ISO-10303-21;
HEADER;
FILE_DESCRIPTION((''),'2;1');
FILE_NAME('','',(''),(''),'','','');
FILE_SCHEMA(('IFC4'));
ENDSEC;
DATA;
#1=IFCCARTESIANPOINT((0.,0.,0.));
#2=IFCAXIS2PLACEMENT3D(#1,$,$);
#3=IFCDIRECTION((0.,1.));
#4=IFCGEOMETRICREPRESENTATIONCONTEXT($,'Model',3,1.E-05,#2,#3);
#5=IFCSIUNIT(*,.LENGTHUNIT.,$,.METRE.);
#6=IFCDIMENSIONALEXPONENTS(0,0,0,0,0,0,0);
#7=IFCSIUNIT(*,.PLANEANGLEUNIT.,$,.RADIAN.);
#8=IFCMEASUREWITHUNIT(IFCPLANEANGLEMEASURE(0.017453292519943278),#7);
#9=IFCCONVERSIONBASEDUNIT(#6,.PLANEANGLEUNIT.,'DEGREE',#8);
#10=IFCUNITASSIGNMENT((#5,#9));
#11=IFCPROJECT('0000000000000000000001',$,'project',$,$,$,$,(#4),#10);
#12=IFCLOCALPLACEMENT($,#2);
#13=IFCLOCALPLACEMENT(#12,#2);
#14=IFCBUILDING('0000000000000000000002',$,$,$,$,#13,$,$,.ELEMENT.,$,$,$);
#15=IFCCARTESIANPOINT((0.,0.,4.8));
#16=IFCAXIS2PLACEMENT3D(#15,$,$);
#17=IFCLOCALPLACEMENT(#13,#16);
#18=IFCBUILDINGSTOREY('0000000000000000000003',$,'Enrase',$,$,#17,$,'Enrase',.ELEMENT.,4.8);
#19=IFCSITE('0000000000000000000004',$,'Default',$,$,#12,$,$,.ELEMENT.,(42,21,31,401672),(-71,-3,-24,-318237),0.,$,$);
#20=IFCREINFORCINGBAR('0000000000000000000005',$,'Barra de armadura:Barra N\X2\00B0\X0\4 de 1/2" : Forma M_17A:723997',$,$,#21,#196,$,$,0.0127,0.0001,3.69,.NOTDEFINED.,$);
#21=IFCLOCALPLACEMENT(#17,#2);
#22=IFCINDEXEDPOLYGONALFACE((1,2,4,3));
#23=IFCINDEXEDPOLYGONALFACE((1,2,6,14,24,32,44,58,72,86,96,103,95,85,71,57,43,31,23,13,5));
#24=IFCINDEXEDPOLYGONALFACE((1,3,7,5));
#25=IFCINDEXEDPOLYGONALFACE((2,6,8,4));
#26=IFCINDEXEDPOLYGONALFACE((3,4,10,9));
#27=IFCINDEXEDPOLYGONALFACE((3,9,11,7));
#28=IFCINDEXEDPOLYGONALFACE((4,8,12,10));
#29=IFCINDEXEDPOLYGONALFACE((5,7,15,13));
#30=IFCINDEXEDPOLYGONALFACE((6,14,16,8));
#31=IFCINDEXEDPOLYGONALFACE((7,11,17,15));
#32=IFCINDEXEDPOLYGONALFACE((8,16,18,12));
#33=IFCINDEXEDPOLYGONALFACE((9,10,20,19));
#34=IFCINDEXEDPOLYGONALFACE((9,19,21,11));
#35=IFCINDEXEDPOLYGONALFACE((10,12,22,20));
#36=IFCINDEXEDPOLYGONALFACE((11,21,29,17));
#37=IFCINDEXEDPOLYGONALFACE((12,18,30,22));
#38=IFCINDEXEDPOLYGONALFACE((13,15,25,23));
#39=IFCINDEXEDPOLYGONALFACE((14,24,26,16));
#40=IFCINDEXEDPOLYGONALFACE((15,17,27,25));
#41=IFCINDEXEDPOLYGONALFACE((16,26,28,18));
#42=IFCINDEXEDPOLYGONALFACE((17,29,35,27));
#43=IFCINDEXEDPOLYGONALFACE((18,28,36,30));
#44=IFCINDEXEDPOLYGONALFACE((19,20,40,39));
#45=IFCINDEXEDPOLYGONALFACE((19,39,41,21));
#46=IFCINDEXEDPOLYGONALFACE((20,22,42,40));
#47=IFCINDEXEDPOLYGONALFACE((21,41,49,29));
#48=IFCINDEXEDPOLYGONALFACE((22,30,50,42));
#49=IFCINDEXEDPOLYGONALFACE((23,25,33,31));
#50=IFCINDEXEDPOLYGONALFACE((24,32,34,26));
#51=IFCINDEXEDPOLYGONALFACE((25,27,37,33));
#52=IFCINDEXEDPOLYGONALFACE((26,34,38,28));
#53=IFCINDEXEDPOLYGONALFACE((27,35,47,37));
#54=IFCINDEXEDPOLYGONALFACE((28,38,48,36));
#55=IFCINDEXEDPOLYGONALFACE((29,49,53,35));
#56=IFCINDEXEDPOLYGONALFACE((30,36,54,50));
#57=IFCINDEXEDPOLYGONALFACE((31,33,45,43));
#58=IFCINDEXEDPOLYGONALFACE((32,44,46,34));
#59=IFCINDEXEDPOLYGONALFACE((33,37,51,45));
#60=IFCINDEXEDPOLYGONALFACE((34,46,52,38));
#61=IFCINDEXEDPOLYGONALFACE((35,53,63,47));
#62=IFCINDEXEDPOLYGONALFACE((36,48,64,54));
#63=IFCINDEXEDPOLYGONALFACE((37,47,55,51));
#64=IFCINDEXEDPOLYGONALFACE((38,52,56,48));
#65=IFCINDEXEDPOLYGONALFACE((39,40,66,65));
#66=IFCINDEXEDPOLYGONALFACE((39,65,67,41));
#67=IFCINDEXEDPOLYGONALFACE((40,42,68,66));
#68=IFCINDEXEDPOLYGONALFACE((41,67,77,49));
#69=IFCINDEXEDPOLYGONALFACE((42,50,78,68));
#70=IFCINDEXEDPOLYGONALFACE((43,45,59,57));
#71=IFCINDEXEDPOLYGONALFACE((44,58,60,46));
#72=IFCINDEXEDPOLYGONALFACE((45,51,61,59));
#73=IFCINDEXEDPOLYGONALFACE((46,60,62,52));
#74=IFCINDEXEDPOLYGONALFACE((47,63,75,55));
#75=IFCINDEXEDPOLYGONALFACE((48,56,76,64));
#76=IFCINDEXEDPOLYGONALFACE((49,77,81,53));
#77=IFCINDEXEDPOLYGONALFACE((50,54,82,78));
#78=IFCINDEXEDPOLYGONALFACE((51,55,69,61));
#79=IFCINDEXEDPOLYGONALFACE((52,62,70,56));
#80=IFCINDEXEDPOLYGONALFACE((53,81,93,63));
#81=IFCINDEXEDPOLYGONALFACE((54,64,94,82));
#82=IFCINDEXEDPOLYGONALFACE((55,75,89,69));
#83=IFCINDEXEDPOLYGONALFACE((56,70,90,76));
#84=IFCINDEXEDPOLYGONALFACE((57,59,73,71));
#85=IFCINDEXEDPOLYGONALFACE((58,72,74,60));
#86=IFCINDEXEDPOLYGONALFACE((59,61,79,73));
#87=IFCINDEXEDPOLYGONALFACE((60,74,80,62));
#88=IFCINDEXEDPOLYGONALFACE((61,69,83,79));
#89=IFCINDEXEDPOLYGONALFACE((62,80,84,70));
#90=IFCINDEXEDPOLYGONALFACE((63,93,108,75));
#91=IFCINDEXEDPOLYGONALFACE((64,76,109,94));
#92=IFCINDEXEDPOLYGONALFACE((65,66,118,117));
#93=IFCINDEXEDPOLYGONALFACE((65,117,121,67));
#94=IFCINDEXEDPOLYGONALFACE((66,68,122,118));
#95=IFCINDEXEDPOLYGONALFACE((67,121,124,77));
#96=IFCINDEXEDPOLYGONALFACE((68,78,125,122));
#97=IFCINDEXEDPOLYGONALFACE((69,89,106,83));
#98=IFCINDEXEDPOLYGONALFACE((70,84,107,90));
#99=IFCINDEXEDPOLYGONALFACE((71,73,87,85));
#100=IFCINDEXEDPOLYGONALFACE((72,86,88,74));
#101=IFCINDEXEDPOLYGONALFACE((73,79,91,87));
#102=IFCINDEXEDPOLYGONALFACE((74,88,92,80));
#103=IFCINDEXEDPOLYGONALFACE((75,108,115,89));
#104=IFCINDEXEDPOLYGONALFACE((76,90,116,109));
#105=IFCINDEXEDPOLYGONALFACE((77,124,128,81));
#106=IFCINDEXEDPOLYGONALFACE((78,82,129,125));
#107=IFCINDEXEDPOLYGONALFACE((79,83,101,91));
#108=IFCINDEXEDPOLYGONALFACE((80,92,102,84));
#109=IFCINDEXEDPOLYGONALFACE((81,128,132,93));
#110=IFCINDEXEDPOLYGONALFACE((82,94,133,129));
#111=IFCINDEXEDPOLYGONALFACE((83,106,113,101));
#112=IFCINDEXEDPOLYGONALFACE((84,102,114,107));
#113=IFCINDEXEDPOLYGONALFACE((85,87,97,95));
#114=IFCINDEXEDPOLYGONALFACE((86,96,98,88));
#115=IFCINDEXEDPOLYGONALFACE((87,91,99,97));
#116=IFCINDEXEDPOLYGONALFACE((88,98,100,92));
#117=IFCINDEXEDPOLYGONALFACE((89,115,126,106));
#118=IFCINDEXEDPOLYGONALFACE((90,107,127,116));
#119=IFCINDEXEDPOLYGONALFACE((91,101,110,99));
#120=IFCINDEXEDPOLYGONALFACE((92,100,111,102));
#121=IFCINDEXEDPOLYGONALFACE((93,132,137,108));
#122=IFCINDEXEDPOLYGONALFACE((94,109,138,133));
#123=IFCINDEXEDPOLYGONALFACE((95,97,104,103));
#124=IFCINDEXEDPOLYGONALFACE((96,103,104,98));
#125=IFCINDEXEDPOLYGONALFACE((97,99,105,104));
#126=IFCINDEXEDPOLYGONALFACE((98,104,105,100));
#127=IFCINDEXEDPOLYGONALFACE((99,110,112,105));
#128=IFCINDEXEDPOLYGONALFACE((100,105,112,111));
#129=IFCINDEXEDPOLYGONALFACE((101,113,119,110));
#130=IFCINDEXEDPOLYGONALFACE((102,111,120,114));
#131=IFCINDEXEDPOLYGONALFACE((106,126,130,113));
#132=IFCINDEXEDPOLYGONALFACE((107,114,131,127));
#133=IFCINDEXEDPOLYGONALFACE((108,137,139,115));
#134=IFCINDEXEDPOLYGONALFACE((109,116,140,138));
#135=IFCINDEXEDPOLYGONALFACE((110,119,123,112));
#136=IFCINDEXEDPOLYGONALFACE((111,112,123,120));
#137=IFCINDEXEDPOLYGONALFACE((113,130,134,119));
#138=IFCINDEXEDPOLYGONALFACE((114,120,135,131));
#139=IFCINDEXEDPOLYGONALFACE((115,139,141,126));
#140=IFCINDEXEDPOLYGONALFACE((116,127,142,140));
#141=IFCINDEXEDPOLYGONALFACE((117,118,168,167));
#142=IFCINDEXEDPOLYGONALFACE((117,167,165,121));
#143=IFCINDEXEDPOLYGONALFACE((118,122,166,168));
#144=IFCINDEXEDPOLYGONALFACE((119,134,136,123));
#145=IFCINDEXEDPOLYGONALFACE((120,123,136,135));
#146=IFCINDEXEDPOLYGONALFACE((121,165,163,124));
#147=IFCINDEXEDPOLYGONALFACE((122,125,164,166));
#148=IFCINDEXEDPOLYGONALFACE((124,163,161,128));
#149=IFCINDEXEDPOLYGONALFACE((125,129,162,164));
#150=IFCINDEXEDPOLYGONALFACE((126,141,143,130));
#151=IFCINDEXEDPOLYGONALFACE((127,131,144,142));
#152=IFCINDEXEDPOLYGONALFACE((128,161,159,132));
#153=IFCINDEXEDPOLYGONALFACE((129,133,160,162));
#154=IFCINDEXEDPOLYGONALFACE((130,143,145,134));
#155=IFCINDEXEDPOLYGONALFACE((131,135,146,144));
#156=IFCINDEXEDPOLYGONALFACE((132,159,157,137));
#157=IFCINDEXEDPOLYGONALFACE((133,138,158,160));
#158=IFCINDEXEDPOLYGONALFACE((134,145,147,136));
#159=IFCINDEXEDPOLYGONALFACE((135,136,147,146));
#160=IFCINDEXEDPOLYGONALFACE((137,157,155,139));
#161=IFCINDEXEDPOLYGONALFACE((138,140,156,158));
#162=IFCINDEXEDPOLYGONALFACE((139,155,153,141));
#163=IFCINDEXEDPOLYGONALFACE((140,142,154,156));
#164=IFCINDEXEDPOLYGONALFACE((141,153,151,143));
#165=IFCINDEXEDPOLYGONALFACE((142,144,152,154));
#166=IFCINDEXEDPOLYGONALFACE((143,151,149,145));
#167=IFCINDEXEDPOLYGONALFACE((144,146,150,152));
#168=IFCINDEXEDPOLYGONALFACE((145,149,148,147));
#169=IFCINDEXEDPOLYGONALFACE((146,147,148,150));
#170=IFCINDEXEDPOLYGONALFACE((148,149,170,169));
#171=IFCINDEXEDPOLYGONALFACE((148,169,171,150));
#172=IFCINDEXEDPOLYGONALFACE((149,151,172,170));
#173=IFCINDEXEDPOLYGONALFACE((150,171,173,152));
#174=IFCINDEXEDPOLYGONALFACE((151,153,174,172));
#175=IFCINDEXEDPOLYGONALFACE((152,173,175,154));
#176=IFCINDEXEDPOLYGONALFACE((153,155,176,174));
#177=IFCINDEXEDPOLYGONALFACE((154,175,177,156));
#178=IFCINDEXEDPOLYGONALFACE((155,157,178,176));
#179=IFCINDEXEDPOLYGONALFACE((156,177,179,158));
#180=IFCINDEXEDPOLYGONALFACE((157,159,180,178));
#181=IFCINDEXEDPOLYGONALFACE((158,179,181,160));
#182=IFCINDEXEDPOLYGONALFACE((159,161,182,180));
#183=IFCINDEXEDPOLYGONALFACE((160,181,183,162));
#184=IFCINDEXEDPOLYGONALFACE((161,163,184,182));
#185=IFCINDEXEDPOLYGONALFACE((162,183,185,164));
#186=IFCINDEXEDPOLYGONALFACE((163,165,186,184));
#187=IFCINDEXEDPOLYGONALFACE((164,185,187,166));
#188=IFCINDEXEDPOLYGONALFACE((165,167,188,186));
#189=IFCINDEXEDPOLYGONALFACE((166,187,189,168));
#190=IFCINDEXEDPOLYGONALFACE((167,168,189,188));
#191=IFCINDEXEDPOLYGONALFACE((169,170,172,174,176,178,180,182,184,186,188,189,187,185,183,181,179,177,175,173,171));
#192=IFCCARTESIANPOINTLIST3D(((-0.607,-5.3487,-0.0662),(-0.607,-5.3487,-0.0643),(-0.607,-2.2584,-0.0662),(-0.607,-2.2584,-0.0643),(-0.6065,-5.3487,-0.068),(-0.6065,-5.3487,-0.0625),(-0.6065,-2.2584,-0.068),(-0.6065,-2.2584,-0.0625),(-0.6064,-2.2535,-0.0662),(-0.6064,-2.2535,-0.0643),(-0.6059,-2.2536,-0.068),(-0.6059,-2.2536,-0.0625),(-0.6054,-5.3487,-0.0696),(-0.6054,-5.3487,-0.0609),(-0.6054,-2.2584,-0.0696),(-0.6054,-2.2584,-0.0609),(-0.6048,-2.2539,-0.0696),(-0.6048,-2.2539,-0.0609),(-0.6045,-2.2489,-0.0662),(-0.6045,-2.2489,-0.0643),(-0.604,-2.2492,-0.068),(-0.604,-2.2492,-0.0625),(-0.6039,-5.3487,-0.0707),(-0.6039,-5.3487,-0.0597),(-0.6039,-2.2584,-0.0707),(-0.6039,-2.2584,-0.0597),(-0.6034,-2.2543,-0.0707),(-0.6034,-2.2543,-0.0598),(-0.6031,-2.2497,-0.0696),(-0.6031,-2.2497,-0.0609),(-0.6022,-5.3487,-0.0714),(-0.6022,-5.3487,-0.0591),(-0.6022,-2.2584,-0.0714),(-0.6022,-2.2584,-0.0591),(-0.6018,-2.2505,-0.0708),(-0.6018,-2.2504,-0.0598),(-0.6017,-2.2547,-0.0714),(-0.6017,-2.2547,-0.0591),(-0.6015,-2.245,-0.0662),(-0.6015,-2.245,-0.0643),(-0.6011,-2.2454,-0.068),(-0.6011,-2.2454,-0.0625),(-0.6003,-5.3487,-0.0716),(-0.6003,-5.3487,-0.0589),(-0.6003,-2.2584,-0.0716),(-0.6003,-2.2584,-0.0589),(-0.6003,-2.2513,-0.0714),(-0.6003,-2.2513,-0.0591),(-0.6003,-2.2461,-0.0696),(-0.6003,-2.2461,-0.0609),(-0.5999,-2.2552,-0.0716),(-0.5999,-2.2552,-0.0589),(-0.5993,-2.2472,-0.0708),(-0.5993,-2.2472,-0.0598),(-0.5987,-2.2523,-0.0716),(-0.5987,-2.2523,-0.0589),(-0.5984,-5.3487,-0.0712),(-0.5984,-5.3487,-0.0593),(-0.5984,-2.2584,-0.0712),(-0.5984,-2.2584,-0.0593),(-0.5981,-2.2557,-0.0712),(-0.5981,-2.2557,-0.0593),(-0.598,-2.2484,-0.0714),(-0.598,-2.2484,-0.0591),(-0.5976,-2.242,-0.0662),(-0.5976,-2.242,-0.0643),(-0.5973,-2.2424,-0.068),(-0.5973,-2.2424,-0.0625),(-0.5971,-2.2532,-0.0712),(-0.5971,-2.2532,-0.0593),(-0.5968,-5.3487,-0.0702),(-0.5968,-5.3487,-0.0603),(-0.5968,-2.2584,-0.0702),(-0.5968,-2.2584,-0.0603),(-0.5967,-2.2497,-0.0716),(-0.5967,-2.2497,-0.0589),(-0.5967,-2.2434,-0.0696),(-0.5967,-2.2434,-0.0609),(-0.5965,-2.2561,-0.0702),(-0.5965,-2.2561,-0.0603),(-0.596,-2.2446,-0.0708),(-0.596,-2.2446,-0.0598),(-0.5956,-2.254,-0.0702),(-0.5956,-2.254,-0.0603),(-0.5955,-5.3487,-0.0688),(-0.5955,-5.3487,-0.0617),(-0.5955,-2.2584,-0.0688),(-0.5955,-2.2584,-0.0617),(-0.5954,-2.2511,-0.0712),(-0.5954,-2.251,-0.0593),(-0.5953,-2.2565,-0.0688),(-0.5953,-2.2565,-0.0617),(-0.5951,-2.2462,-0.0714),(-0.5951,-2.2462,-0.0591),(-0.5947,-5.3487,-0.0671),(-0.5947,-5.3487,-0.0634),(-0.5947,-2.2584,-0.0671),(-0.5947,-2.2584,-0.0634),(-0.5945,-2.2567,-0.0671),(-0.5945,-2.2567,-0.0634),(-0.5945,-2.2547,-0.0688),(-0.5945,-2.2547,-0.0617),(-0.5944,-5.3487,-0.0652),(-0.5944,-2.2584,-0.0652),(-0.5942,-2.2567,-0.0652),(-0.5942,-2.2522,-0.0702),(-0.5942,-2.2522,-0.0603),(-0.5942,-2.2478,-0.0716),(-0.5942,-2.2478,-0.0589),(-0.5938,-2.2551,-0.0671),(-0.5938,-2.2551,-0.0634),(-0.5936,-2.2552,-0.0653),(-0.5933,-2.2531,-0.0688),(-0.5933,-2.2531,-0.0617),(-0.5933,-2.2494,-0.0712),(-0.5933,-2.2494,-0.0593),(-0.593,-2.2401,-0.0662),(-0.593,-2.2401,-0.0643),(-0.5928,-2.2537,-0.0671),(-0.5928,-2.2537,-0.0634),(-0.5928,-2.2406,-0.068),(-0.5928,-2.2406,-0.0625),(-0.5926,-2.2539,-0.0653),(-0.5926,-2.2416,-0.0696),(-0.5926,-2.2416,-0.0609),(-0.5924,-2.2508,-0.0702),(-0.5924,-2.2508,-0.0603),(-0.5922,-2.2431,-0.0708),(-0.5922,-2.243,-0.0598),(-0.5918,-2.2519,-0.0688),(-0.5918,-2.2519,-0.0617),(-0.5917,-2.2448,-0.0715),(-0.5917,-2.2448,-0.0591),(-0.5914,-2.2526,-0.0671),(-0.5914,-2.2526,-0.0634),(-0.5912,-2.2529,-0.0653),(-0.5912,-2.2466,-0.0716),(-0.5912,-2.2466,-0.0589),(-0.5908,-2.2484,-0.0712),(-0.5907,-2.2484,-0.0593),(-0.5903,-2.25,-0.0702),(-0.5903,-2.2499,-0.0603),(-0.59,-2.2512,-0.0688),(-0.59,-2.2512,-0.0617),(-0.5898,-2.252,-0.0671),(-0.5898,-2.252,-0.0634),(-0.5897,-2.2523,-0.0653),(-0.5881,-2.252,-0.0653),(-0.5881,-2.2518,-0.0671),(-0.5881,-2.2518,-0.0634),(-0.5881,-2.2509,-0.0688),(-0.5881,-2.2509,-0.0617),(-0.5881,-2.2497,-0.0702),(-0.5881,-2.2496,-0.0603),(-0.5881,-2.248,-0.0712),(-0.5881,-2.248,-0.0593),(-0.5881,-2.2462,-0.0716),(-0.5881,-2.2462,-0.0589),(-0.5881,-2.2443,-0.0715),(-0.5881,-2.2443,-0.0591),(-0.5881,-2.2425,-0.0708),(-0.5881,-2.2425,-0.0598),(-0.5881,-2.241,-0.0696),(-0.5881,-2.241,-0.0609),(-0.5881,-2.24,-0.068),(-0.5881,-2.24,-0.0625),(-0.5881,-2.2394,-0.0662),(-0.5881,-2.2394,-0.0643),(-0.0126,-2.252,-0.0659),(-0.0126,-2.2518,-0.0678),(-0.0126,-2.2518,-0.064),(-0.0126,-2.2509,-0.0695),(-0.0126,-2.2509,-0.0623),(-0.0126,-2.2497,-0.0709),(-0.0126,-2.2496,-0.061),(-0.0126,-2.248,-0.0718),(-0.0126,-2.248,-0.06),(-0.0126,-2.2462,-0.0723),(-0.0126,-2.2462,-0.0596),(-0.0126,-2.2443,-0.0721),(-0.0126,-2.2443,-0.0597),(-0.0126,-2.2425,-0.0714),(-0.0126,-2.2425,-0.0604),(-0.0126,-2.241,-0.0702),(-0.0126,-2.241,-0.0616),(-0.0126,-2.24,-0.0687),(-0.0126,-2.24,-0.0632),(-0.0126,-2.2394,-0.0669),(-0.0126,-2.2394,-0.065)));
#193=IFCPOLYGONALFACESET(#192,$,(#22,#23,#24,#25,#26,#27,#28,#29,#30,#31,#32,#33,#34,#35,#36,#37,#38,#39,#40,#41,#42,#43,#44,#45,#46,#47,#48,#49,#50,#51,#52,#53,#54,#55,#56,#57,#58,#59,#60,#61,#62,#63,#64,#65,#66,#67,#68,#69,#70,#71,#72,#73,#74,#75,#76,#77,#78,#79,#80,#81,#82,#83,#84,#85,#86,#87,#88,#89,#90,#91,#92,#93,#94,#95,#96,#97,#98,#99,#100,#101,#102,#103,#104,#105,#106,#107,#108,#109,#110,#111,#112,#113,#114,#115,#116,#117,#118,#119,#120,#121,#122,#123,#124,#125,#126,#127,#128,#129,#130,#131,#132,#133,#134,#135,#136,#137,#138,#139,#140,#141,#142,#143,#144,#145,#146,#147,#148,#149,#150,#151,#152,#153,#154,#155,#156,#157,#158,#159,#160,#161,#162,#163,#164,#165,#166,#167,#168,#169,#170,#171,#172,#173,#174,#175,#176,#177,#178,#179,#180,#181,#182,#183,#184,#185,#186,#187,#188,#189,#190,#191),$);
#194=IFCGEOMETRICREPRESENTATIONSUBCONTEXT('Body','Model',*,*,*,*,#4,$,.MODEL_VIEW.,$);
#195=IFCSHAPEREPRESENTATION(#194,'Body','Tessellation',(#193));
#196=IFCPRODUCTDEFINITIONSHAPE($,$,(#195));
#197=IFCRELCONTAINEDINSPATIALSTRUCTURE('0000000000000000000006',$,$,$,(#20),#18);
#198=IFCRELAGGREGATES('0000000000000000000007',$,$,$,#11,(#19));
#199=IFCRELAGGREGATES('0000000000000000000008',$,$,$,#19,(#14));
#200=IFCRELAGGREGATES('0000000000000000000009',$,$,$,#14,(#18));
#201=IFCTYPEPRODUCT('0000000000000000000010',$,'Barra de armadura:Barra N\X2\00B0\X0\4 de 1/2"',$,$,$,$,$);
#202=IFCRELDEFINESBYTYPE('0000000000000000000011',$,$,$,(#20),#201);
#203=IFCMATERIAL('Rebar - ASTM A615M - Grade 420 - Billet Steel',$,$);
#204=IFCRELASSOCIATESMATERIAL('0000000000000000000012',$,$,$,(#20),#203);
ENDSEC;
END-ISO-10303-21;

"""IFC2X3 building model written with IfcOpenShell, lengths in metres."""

from ifc_helpers import new_model, entity, si_unit, converted_unit, direction, frame, origin, place, context, subcontext, project, spatial, material, type_object, element, save


model = new_model("IFC2X3")

# Units and contexts
model_context = context("Model", 3, precision=1e-05, world=origin(), true_north=direction((0.0, 1.0)))
body_context = subcontext(model_context, "Body", "Model", "MODEL_VIEW")
ifc_project = project(units=[si_unit("LENGTHUNIT", "METRE"), converted_unit("PLANEANGLEUNIT", "DEGREE", entity("IfcPlaneAngleMeasure", 0.017453292519943278), si_unit("PLANEANGLEUNIT", "RADIAN"), dimensions=[0, 0, 0, 0, 0, 0, 0])], contexts=[model_context])

# Site, building, storey
site_placement = place(None, origin())
site = spatial("IfcSite", under=ifc_project, at=site_placement, Name="Default", CompositionType="ELEMENT", RefLatitude=(42, 21, 31, 401672), RefLongitude=(-71, -3, -24, -318237), RefElevation=0.0)
building_placement = place(site_placement, origin())
building = spatial("IfcBuilding", under=site, at=building_placement, CompositionType="ELEMENT")
storey_placement = place(building_placement, frame((0.0, 0.0, 4.8)))
storey = spatial("IfcBuildingStorey", under=building, at=storey_placement, Name="Enrase", LongName="Enrase", CompositionType="ELEMENT", Elevation=4.8)

# Reinforcing bar
ifc_material = material(Name="Rebar - ASTM A615M - Grade 420 - Billet Steel")
type_product_1 = type_object("IfcTypeProduct", Name="Barra de armadura:Barra N°4 de 1/2\"")
reinforcing_bar_1_placement = place(storey_placement, origin())
element("IfcReinforcingBar", 1, at=reinforcing_bar_1_placement, inside=storey, type_object=type_product_1, material=ifc_material, Name="Barra de armadura:Barra N°4 de 1/2\" : Forma M_17A:723997", BarLength=3.69, BarRole="NOTDEFINED", CrossSectionArea=0.0001, NominalDiameter=0.0127, context=body_context, shape_type="AdvancedSweptSolid", body=[
    entity("IfcSweptDiskSolid", entity("IfcCompositeCurve", [entity("IfcCompositeCurveSegment", "CONTINUOUS", True, entity("IfcPolyline", [entity("IfcCartesianPoint", [-0.6008, -5.3487, -0.0652]), entity("IfcCartesianPoint", [-0.6008, -2.2584, -0.0652])])), entity("IfcCompositeCurveSegment", "CONTINUOUS", True, entity("IfcTrimmedCurve", entity("IfcCircle", entity("IfcAxis2Placement3D", entity("IfcCartesianPoint", [-0.5881, -2.2584, -0.0653]), entity("IfcDirection", [-0.001144, 0.0, -0.999999]), entity("IfcDirection", [0.0, 1.0, 0.0])), 0.0127), [entity("IfcParameterValue", 270.0)], [entity("IfcParameterValue", 360.0)], True, "PARAMETER")), entity("IfcCompositeCurveSegment", "CONTINUOUS", True, entity("IfcPolyline", [entity("IfcCartesianPoint", [-0.5881, -2.2457, -0.0653]), entity("IfcCartesianPoint", [-0.0126, -2.2457, -0.0659])]))], False), 0.0063, None, 0.0, 92.0),
])

save(model, "model.ifc")
